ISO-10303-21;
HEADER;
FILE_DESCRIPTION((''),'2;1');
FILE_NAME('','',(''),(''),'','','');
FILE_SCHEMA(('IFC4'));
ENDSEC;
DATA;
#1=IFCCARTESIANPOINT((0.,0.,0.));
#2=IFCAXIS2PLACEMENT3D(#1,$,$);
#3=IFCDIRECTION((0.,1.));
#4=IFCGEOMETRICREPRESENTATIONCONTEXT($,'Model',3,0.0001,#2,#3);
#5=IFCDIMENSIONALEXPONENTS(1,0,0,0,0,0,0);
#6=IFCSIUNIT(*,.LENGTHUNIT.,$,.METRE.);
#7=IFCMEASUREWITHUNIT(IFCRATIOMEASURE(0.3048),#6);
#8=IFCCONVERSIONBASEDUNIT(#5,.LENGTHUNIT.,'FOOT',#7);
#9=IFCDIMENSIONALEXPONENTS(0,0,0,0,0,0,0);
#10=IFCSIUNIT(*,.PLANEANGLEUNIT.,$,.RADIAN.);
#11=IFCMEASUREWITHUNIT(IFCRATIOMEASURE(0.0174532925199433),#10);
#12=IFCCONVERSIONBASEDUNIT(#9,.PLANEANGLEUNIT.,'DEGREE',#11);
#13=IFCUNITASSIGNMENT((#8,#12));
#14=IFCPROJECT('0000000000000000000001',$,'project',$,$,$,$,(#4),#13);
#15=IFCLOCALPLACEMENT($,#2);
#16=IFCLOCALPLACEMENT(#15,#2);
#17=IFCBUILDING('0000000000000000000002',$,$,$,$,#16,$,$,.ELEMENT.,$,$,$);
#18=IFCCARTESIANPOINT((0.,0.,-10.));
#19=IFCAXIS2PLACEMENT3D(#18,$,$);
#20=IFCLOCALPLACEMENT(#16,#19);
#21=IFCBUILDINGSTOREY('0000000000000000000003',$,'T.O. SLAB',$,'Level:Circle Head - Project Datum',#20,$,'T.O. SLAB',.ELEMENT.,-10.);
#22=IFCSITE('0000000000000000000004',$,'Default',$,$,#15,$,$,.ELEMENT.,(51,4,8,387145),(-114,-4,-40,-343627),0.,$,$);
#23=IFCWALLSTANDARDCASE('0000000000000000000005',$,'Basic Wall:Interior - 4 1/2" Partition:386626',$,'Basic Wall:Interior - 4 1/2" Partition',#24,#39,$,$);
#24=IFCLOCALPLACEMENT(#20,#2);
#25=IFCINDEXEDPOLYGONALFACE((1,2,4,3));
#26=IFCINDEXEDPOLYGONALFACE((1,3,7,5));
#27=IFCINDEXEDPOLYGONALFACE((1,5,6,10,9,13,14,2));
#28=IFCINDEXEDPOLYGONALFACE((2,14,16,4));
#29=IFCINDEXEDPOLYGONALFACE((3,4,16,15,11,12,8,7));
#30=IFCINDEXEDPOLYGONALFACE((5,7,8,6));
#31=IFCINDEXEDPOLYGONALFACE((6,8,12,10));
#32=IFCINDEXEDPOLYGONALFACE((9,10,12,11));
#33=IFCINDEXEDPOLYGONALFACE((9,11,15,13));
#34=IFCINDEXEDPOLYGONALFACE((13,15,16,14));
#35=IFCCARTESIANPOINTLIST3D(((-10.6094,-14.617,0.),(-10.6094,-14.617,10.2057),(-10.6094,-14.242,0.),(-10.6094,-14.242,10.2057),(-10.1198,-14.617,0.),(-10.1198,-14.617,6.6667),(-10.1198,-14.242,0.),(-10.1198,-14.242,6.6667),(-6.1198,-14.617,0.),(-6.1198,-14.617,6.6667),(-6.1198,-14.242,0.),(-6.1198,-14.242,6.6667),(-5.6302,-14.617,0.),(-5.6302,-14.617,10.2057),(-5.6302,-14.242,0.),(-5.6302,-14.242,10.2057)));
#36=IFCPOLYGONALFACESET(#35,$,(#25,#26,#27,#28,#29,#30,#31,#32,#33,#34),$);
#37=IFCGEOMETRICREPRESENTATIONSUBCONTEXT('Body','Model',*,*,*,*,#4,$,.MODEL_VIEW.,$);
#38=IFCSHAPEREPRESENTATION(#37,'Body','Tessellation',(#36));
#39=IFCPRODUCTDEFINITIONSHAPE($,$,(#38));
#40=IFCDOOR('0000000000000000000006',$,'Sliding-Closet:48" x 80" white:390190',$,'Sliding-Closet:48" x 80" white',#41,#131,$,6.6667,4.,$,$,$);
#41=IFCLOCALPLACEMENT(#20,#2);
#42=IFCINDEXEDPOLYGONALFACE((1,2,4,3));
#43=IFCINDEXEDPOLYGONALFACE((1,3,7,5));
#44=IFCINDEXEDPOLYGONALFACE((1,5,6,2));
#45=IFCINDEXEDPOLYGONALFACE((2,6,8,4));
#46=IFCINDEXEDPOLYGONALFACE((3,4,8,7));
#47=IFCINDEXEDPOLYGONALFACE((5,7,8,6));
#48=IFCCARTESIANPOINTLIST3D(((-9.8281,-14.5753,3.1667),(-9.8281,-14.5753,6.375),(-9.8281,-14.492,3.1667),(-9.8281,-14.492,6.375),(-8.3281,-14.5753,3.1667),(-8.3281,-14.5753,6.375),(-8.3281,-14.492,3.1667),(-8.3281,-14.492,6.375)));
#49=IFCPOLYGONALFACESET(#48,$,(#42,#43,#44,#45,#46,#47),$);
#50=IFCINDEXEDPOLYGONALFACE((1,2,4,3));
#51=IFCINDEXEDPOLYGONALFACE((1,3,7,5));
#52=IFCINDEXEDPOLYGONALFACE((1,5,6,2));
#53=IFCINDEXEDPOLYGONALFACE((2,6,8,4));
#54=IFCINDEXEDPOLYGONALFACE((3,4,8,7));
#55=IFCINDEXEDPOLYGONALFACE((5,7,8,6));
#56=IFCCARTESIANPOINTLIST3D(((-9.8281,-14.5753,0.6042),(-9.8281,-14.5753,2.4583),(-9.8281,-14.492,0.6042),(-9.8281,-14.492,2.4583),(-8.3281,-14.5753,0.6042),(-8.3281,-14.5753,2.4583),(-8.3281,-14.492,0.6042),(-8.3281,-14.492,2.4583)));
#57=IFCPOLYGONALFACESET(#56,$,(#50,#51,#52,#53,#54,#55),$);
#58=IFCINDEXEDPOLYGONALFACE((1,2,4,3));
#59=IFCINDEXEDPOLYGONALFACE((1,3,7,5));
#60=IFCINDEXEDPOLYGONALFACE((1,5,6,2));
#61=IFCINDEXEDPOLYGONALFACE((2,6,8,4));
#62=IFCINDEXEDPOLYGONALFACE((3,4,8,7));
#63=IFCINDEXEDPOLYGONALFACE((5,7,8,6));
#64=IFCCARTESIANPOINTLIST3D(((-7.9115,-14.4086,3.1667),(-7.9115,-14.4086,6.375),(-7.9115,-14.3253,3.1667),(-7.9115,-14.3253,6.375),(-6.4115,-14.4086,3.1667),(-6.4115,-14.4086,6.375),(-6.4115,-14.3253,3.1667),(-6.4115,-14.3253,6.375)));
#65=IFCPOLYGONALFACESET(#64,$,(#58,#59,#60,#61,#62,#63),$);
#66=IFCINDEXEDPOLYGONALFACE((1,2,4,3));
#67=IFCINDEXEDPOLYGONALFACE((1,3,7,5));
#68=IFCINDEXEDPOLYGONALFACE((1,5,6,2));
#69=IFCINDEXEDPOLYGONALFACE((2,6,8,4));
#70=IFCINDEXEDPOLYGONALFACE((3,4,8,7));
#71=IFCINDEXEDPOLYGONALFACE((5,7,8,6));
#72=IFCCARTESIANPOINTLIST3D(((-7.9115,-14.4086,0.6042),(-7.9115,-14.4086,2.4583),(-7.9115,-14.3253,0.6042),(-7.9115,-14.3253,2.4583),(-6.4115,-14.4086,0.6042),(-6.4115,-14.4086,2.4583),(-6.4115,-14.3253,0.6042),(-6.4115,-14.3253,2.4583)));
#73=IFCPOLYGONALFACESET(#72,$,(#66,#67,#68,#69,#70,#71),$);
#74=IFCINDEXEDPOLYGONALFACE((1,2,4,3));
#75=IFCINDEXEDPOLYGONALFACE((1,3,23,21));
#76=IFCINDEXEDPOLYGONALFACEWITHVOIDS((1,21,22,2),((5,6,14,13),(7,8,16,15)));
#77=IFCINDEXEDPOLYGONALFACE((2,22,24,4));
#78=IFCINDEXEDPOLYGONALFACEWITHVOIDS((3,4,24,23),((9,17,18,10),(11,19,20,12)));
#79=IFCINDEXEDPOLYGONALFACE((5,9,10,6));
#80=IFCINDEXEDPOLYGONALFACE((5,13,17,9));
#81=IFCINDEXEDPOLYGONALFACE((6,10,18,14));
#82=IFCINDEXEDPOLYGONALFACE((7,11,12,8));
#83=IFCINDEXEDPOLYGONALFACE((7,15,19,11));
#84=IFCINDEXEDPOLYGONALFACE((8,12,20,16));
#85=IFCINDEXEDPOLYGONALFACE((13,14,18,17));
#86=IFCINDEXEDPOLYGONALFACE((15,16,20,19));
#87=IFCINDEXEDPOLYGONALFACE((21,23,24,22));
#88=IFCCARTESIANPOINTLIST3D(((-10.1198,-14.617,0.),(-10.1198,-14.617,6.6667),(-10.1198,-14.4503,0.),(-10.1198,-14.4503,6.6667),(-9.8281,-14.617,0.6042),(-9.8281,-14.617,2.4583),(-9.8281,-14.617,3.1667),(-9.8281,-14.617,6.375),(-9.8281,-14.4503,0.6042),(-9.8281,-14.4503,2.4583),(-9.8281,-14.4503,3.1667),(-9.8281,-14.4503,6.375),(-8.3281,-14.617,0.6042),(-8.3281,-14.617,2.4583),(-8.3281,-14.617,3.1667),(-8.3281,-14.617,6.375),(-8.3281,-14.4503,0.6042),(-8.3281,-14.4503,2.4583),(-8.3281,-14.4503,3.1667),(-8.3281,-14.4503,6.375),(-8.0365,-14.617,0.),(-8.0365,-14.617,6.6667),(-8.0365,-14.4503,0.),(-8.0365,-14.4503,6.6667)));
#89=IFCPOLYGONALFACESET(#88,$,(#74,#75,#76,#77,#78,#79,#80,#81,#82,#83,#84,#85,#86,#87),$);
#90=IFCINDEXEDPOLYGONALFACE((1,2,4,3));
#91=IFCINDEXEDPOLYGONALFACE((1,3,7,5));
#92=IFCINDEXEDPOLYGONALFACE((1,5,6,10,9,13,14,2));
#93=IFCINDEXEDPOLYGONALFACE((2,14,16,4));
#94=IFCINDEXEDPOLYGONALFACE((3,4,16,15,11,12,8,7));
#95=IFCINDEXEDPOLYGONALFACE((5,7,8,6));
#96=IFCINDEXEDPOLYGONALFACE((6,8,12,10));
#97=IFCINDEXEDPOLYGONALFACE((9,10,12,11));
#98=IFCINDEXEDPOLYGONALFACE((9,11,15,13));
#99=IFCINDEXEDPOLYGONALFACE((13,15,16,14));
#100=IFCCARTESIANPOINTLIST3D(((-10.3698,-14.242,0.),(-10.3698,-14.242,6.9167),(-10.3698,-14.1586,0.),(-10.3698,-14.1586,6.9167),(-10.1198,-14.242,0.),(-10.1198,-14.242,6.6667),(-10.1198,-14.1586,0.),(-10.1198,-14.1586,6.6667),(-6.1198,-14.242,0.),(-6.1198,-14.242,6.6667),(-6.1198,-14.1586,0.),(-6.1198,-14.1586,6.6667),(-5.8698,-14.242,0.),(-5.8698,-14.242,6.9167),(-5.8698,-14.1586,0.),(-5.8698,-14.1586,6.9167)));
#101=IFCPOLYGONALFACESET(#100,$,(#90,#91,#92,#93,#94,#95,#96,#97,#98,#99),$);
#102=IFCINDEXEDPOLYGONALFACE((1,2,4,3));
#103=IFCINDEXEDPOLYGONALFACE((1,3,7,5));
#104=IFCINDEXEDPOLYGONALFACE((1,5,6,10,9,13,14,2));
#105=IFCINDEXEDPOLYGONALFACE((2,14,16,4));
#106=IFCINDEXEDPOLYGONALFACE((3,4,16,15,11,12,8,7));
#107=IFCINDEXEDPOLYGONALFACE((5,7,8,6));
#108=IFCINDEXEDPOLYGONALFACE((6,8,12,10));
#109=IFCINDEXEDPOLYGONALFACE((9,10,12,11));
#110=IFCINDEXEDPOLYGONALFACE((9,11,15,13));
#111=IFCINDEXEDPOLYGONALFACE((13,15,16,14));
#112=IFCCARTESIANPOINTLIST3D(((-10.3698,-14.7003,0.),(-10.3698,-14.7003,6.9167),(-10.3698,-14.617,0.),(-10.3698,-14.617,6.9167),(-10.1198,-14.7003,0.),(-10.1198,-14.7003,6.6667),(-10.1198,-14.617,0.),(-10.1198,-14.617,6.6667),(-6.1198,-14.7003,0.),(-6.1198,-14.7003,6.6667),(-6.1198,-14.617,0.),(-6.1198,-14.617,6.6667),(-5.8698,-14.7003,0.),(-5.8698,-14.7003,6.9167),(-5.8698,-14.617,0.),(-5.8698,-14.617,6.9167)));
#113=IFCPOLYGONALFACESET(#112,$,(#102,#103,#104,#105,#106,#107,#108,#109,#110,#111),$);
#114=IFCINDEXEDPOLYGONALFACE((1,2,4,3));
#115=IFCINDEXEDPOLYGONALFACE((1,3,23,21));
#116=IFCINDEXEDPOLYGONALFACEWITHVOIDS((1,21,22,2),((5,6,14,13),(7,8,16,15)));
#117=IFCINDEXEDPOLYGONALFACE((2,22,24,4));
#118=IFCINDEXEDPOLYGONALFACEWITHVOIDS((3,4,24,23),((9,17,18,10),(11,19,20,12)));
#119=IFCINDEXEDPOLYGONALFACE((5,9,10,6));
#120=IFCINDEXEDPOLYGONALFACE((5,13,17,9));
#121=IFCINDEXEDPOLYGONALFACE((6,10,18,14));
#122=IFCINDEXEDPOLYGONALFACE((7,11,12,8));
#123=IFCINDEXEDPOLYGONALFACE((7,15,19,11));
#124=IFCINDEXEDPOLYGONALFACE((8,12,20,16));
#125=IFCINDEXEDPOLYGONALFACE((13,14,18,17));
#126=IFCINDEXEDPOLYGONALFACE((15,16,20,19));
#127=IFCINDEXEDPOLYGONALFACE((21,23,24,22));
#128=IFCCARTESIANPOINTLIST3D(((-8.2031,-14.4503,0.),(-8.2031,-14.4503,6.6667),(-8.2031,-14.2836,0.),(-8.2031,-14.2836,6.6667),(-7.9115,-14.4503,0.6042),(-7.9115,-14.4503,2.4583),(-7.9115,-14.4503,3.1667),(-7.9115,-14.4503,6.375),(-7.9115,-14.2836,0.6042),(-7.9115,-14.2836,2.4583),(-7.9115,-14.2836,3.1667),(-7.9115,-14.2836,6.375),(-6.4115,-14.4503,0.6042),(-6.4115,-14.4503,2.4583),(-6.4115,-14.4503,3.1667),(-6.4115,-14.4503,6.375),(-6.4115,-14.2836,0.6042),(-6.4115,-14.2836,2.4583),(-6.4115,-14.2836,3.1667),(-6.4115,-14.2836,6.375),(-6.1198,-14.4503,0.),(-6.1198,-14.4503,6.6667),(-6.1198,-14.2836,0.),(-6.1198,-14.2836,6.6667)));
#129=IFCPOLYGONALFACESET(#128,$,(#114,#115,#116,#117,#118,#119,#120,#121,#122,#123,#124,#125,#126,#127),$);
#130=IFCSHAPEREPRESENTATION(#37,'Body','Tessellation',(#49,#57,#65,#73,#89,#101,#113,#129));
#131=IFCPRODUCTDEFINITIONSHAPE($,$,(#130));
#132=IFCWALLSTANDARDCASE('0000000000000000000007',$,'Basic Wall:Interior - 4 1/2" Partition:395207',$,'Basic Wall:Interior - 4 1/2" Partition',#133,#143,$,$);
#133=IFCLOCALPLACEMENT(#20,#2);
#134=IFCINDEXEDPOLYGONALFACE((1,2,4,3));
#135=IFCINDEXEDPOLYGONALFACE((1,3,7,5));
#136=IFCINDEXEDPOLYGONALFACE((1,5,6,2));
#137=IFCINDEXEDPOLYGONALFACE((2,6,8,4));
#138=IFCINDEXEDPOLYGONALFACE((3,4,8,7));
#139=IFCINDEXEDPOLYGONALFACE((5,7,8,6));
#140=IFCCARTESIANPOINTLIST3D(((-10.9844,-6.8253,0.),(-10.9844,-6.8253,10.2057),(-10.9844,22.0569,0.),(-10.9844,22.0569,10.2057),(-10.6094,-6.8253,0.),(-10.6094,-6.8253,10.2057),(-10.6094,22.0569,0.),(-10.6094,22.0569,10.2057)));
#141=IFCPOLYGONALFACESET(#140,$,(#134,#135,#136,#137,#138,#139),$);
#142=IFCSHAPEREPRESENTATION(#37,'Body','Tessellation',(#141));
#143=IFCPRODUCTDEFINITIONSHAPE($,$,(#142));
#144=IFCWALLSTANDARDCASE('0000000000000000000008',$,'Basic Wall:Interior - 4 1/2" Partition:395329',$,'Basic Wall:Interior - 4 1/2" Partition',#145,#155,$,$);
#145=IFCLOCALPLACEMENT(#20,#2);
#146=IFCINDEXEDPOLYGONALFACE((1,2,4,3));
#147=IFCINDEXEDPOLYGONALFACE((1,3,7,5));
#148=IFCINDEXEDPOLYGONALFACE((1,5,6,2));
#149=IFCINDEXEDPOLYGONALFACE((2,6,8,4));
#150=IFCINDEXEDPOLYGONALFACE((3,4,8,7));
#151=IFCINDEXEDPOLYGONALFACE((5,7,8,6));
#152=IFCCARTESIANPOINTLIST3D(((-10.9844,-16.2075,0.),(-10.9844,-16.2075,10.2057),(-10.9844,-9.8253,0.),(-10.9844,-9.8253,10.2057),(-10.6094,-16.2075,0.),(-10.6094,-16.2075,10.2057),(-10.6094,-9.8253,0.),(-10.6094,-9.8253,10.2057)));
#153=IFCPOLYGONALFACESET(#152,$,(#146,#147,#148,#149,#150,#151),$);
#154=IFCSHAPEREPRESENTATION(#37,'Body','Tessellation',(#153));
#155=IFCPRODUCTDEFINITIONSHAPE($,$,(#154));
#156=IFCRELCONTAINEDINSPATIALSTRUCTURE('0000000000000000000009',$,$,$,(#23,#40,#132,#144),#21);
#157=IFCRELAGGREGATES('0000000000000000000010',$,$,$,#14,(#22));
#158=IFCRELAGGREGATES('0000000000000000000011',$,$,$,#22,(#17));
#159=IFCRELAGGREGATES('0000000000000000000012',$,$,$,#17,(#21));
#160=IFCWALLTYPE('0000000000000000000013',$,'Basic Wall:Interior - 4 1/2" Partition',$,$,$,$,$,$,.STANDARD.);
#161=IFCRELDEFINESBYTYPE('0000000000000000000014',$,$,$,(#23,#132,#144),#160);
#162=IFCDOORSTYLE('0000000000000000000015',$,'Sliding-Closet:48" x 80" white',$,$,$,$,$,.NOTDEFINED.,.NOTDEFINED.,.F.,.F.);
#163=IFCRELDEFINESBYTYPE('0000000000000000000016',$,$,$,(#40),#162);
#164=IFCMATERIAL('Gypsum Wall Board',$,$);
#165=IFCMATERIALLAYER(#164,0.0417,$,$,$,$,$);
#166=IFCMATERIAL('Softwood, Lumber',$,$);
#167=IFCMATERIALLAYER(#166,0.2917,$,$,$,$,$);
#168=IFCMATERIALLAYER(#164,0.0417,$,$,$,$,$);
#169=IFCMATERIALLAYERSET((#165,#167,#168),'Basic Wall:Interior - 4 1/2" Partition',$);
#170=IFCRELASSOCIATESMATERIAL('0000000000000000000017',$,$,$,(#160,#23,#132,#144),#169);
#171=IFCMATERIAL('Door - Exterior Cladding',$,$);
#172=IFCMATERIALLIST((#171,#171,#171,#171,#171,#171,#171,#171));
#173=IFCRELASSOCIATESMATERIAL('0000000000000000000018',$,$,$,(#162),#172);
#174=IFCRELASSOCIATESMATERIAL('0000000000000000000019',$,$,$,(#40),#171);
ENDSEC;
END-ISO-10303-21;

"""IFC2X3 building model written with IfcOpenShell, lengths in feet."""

from ifc_helpers import new_model, entity, si_unit, converted_unit, direction, frame, frame_2d, origin, origin_2d_with_axis, place, context, subcontext, project, spatial, polyline, rectangle, outline, extrude, source, transform, mapped, material, material_list, layer, layer_set, layer_usage, type_object, type_shapes, element, fill, save


model = new_model("IFC2X3")

# Units and contexts
model_context = context("Model", 3, precision=0.0001, world=origin(), true_north=direction((0.0, 1.0)))
body_context = subcontext(model_context, "Body", "Model", "MODEL_VIEW")
ifc_project = project(units=[converted_unit("LENGTHUNIT", "FOOT", entity("IfcRatioMeasure", 0.3048), si_unit("LENGTHUNIT", "METRE"), dimensions=[1, 0, 0, 0, 0, 0, 0]), converted_unit("PLANEANGLEUNIT", "DEGREE", entity("IfcRatioMeasure", 0.0174532925199433), si_unit("PLANEANGLEUNIT", "RADIAN"), dimensions=[0, 0, 0, 0, 0, 0, 0])], contexts=[model_context])

# Site, building, storey
site_placement = place(None, origin())
site = spatial("IfcSite", under=ifc_project, at=site_placement, Name="Default", CompositionType="ELEMENT", RefLatitude=(51, 4, 8, 387145), RefLongitude=(-114, -4, -40, -343627), RefElevation=0.0)
building_placement = place(site_placement, origin())
building = spatial("IfcBuilding", under=site, at=building_placement, CompositionType="ELEMENT")
storey_placement = place(building_placement, frame((0.0, 0.0, -10.0)))
storey = spatial("IfcBuildingStorey", under=building, at=storey_placement, Name="T.O. SLAB", ObjectType="Level:Circle Head - Project Datum", LongName="T.O. SLAB", CompositionType="ELEMENT", Elevation=-10.0)

# Shared definitions
ifc_material_1 = material(Name="Gypsum Wall Board")
ifc_layer_1 = layer(ifc_material_1, 0.0417)
ifc_material_2 = material(Name="Softwood, Lumber")
ifc_layer_2 = layer(ifc_material_2, 0.2917)
ifc_layer_3 = layer(ifc_material_1, 0.0417)
ifc_layer_set_1 = layer_set([ifc_layer_1, ifc_layer_2, ifc_layer_3], Name="Basic Wall:Interior - 4 1/2\" Partition")
wall_type_1 = type_object("IfcWallType", Name="Basic Wall:Interior - 4 1/2\" Partition", PredefinedType="STANDARD", material=ifc_layer_set_1)

# Shared definitions
ifc_material_3 = material(Name="Door - Exterior Cladding")

# Wall, opening, door
ifc_layer_usage_1 = layer_usage(ifc_layer_set_1, "AXIS2", "NEGATIVE", 0.1875)
wall_1_placement = place(storey_placement, frame((-5.6302, -14.4295, 0.0), z_axis=(0.0, 0.0, 1.0), x_axis=(-1.0, 0.0, 0.0)))
wall_1 = element("IfcWallStandardCase", 1, at=wall_1_placement, inside=storey, type_object=wall_type_1, material=ifc_layer_usage_1, Name="Basic Wall:Interior - 4 1/2\" Partition:386626", ObjectType="Basic Wall:Interior - 4 1/2\" Partition", context=body_context, shape_type="SweptSolid", body=[
    extrude(rectangle(XDim=4.9792, YDim=0.375, at=frame_2d((2.4896, 0.0), x_axis=(-1.0, 0.0))), origin(), (0.0, 0.0, 1.0), 10.2057),
])
opening_1_placement = place(wall_1_placement, frame((0.4896, -0.1875, 0.0)))
opening_1 = element("IfcOpeningElement", 2, at=opening_1_placement, cuts=wall_1, ObjectType="Opening", context=body_context, shape_type="SweptSolid", body=[
    extrude(rectangle(XDim=6.6667, YDim=4.0, at=frame_2d((3.3333, 2.0), x_axis=(-1.0, 0.0))), frame((0.0, 0.0, 0.0), z_axis=(0.0, 1.0, 0.0), x_axis=(0.0, 0.0, 1.0)), (0.0, 0.0, 1.0), 0.375),
])
ifc_material_list_1 = material_list([ifc_material_3, ifc_material_3, ifc_material_3, ifc_material_3, ifc_material_3, ifc_material_3, ifc_material_3, ifc_material_3])
door_style_1 = type_object("IfcDoorStyle", Name="Sliding-Closet:48\" x 80\" white", ConstructionType="NOTDEFINED", OperationType="NOTDEFINED", ParameterTakesPrecedence=False, Sizeable=False, material=ifc_material_list_1)
shared_shape_1 = source(origin(), body_context, "Body", "SweptSolid", [
    extrude(rectangle(XDim=1.5, YDim=0.0833, at=origin_2d_with_axis()), frame((2.9583, 1.125, 3.1667)), (0.0, 0.0, 1.0), 3.2083),
    extrude(rectangle(XDim=1.5, YDim=0.0833, at=frame_2d((0.0, 0.0), x_axis=(1.0, 0.0))), frame((2.9583, 1.125, 0.6042)), (0.0, 0.0, 1.0), 1.8542),
    extrude(rectangle(XDim=1.5, YDim=0.0833, at=origin_2d_with_axis()), frame((1.0417, 0.9583, 3.1667), z_axis=(0.0, 0.0, 1.0), x_axis=(-1.0, 0.0, 0.0)), (0.0, 0.0, 1.0), 3.2083),
    extrude(rectangle(XDim=1.5, YDim=0.0833, at=origin_2d_with_axis()), frame((1.0417, 0.9583, 0.6042), z_axis=(0.0, 0.0, 1.0), x_axis=(-1.0, 0.0, 0.0)), (0.0, 0.0, 1.0), 1.8542),
    extrude(outline(polyline([(-3.3333, -1.0417), (3.3333, -1.0417), (3.3333, 1.0417), (-3.3333, 1.0417), (-3.3333, -1.0417)]), holes=[polyline([(2.7292, 0.75), (2.7292, -0.75), (0.875, -0.75), (0.875, 0.75), (2.7292, 0.75)]), polyline([(0.1667, 0.75), (0.1667, -0.75), (-3.0417, -0.75), (-3.0417, 0.75), (0.1667, 0.75)])]), frame((2.9583, 1.2083, 3.3333), z_axis=(0.0, -1.0, 0.0), x_axis=(0.0, 0.0, -1.0)), (0.0, 0.0, 1.0), 0.1667),
    extrude(outline(polyline([(-3.3958, -2.25), (3.5208, -2.25), (3.5208, 2.25), (-3.3958, 2.25), (-3.3958, 2.0), (3.2708, 2.0), (3.2708, -2.0), (-3.3958, -2.0), (-3.3958, -2.25)])), frame((2.0, 0.8333, 3.3958), z_axis=(0.0, -1.0, 0.0), x_axis=(0.0, 0.0, 1.0)), (0.0, 0.0, 1.0), 0.0833),
    extrude(outline(polyline([(-2.25, -3.3958), (-2.0, -3.3958), (-2.0, 3.2708), (2.0, 3.2708), (2.0, -3.3958), (2.25, -3.3958), (2.25, 3.5208), (-2.25, 3.5208), (-2.25, -3.3958)])), frame((2.0, 1.2917, 3.3958), z_axis=(0.0, -1.0, 0.0), x_axis=(1.0, 0.0, 0.0)), (0.0, 0.0, 1.0), 0.0833),
    extrude(outline(polyline([(-1.0417, -3.3333), (1.0417, -3.3333), (1.0417, 3.3333), (-1.0417, 3.3333), (-1.0417, -3.3333)]), holes=[polyline([(0.75, 0.1667), (0.75, -3.0417), (-0.75, -3.0417), (-0.75, 0.1667), (0.75, 0.1667)]), polyline([(0.75, 2.7292), (0.75, 0.875), (-0.75, 0.875), (-0.75, 2.7292), (0.75, 2.7292)])]), frame((1.0417, 1.0417, 3.3333), z_axis=(0.0, -1.0, 0.0), x_axis=(-1.0, 0.0, 0.0)), (0.0, 0.0, 1.0), 0.1667),
])
type_shapes(door_style_1, [shared_shape_1])
door_1_placement = place(opening_1_placement, frame((0.0, -0.8333, 0.0)))
door_1 = element("IfcDoor", 3, at=door_1_placement, inside=storey, type_object=door_style_1, material=ifc_material_3, Name="Sliding-Closet:48\" x 80\" white:390190", ObjectType="Sliding-Closet:48\" x 80\" white", OverallHeight=6.6667, OverallWidth=4.0, context=body_context, shape_type="MappedRepresentation", body=[
    mapped(shared_shape_1, transform((0.0, 0.0, 0.0), scale=1.0)),
])
fill(opening_1, door_1)

# Walls
ifc_layer_usage_2 = layer_usage(ifc_layer_set_1, "AXIS2", "NEGATIVE", 0.1875)
wall_2_placement = place(storey_placement, frame((-10.7969, -6.8253, 0.0), z_axis=(0.0, 0.0, 1.0), x_axis=(0.0, 1.0, 0.0)))
element("IfcWallStandardCase", 4, at=wall_2_placement, inside=storey, type_object=wall_type_1, material=ifc_layer_usage_2, Name="Basic Wall:Interior - 4 1/2\" Partition:395207", ObjectType="Basic Wall:Interior - 4 1/2\" Partition", context=body_context, shape_type="SweptSolid", body=[
    extrude(rectangle(XDim=28.8822, YDim=0.375, at=frame_2d((14.4411, 0.0), x_axis=(-1.0, 0.0))), origin(), (0.0, 0.0, 1.0), 10.2057),
])
ifc_layer_usage_3 = layer_usage(ifc_layer_set_1, "AXIS2", "NEGATIVE", 0.1875)
wall_3_placement = place(storey_placement, frame((-10.7969, -16.2075, 0.0), z_axis=(0.0, 0.0, 1.0), x_axis=(0.0, 1.0, 0.0)))
element("IfcWallStandardCase", 5, at=wall_3_placement, inside=storey, type_object=wall_type_1, material=ifc_layer_usage_3, Name="Basic Wall:Interior - 4 1/2\" Partition:395329", ObjectType="Basic Wall:Interior - 4 1/2\" Partition", context=body_context, shape_type="SweptSolid", body=[
    extrude(rectangle(XDim=6.3822, YDim=0.375, at=frame_2d((3.1911, 0.0), x_axis=(-1.0, 0.0))), origin(), (0.0, 0.0, 1.0), 10.2057),
])

save(model, "model.ifc")
